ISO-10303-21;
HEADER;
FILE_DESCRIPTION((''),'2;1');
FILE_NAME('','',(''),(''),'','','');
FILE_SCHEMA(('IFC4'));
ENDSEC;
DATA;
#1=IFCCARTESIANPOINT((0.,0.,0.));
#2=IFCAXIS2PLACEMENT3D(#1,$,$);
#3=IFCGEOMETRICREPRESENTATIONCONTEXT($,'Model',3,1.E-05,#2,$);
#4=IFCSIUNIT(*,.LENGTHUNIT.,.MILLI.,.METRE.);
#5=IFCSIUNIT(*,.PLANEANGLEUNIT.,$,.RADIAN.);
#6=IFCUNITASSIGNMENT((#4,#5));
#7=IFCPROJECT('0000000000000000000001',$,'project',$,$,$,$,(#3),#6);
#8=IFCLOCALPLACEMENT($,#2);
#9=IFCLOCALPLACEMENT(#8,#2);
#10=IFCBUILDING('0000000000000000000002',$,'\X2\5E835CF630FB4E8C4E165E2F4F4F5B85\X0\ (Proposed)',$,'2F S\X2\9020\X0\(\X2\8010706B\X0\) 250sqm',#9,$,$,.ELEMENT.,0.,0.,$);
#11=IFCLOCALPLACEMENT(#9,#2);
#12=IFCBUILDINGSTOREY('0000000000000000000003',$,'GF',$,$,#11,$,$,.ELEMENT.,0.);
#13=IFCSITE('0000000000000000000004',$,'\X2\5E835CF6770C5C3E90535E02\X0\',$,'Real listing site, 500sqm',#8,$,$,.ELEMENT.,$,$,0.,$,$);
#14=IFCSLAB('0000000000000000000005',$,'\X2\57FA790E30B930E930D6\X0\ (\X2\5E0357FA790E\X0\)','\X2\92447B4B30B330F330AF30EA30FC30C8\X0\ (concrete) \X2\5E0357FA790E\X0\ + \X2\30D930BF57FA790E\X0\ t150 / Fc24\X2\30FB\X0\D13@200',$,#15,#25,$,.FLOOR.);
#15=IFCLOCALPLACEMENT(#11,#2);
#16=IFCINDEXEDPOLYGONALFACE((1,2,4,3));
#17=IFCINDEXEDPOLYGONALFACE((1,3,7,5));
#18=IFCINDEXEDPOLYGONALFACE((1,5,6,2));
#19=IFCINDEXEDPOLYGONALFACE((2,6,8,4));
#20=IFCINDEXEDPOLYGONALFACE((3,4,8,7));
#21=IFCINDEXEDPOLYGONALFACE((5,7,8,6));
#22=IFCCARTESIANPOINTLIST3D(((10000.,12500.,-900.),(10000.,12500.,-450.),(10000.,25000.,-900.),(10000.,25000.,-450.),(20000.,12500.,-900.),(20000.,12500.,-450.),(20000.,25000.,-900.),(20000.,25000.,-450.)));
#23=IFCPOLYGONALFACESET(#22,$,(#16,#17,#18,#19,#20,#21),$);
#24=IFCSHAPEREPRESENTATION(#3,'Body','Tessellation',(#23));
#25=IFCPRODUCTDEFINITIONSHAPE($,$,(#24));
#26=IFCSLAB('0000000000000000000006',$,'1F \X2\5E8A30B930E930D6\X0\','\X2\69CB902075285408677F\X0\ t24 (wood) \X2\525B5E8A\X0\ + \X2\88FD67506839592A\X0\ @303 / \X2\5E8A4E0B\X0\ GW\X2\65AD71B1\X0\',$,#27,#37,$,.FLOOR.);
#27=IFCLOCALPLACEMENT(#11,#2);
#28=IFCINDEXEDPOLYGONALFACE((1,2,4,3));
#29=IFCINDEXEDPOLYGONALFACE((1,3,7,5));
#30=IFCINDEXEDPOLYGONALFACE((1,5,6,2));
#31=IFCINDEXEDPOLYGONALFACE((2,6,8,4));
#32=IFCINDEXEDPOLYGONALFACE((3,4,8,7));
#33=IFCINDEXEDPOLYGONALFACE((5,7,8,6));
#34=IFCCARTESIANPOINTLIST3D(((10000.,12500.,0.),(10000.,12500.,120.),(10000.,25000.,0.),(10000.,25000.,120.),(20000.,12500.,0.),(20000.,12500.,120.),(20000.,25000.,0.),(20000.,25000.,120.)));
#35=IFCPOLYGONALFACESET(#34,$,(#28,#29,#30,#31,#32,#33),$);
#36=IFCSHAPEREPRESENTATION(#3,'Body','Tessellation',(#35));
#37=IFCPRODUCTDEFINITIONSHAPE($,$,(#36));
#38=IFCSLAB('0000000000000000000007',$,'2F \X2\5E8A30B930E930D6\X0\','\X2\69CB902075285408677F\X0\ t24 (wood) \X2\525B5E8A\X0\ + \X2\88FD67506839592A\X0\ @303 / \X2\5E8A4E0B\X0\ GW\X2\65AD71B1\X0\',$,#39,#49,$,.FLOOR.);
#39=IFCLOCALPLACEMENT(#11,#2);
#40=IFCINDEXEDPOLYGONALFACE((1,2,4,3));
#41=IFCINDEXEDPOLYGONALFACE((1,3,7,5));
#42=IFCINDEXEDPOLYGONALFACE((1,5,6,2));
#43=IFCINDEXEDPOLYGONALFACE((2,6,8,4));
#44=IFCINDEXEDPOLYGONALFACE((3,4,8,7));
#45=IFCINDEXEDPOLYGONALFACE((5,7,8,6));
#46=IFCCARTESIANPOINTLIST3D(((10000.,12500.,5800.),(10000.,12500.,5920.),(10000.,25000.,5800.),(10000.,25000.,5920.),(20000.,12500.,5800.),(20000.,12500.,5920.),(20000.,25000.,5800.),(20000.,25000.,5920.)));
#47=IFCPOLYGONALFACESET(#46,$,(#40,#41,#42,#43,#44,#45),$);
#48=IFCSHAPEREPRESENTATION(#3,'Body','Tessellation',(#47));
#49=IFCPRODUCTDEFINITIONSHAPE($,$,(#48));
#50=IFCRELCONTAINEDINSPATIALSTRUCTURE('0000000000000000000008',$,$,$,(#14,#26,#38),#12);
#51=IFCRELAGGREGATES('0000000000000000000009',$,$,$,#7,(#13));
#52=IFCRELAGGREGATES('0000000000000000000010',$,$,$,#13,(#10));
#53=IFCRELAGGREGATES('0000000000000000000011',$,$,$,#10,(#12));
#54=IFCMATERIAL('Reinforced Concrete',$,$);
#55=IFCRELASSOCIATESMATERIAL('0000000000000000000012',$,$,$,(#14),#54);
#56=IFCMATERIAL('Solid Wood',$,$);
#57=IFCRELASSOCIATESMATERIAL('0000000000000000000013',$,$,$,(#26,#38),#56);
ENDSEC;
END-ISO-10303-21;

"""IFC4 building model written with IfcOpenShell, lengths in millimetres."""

from ifc_helpers import new_model, si_unit, frame, frame_2d, origin, place, context, project, spatial, rectangle, extrude, material, element, save


model = new_model("IFC4")

# Units and contexts
model_context = context("Model", 3, precision=1e-05, world=origin())
ifc_project = project(units=[si_unit("LENGTHUNIT", "METRE", prefix="MILLI"), si_unit("PLANEANGLEUNIT", "RADIAN")], contexts=[model_context])

# Site, building, storey
site_placement = place(None, origin())
site = spatial("IfcSite", under=ifc_project, at=site_placement, Name="広島県尾道市", ObjectType="Real listing site, 500sqm", CompositionType="ELEMENT", RefElevation=0.0)
building_placement = place(site_placement, origin())
building = spatial("IfcBuilding", under=site, at=building_placement, Name="広島・二世帯住宅 (Proposed)", ObjectType="2F S造(耐火) 250sqm", CompositionType="ELEMENT", ElevationOfRefHeight=0.0, ElevationOfTerrain=0.0)
storey_placement = place(building_placement, origin())
storey = spatial("IfcBuildingStorey", under=building, at=storey_placement, Name="GF", CompositionType="ELEMENT", Elevation=0.0)

# Shared definitions
ifc_material_1 = material(Name="Solid Wood")

# Slabs
ifc_material_2 = material(Name="Reinforced Concrete")
slab_1_placement = place(storey_placement, frame((5000.0, 6250.0, -450.0)))
element("IfcSlab", 1, at=slab_1_placement, inside=storey, material=ifc_material_2, Name="基礎スラブ (布基礎)", Description="鉄筋コンクリート (concrete) 布基礎 + ベタ基礎 t150 / Fc24・D13@200", PredefinedType="FLOOR", context=model_context, shape_type="SweptSolid", body=[
    extrude(rectangle(XDim=10000.0, YDim=12500.0, at=frame_2d((5000.0, 6250.0))), frame((5000.0, 6250.0, -450.0)), (0.0, 0.0, 1.0), 450.0),
])
slab_2_placement = place(storey_placement, frame((5000.0, 6250.0, 0.0)))
element("IfcSlab", 2, at=slab_2_placement, inside=storey, material=ifc_material_1, Name="1F 床スラブ", Description="構造用合板 t24 (wood) 剛床 + 製材根太 @303 / 床下 GW断熱", PredefinedType="FLOOR", context=model_context, shape_type="SweptSolid", body=[
    extrude(rectangle(XDim=10000.0, YDim=12500.0, at=frame_2d((5000.0, 6250.0))), frame((5000.0, 6250.0, 0.0)), (0.0, 0.0, 1.0), 120.0),
])
slab_3_placement = place(storey_placement, frame((5000.0, 6250.0, 2900.0)))
element("IfcSlab", 3, at=slab_3_placement, inside=storey, material=ifc_material_1, Name="2F 床スラブ", Description="構造用合板 t24 (wood) 剛床 + 製材根太 @303 / 床下 GW断熱", PredefinedType="FLOOR", context=model_context, shape_type="SweptSolid", body=[
    extrude(rectangle(XDim=10000.0, YDim=12500.0, at=frame_2d((5000.0, 6250.0))), frame((5000.0, 6250.0, 2900.0)), (0.0, 0.0, 1.0), 120.0),
])

save(model, "model.ifc")
